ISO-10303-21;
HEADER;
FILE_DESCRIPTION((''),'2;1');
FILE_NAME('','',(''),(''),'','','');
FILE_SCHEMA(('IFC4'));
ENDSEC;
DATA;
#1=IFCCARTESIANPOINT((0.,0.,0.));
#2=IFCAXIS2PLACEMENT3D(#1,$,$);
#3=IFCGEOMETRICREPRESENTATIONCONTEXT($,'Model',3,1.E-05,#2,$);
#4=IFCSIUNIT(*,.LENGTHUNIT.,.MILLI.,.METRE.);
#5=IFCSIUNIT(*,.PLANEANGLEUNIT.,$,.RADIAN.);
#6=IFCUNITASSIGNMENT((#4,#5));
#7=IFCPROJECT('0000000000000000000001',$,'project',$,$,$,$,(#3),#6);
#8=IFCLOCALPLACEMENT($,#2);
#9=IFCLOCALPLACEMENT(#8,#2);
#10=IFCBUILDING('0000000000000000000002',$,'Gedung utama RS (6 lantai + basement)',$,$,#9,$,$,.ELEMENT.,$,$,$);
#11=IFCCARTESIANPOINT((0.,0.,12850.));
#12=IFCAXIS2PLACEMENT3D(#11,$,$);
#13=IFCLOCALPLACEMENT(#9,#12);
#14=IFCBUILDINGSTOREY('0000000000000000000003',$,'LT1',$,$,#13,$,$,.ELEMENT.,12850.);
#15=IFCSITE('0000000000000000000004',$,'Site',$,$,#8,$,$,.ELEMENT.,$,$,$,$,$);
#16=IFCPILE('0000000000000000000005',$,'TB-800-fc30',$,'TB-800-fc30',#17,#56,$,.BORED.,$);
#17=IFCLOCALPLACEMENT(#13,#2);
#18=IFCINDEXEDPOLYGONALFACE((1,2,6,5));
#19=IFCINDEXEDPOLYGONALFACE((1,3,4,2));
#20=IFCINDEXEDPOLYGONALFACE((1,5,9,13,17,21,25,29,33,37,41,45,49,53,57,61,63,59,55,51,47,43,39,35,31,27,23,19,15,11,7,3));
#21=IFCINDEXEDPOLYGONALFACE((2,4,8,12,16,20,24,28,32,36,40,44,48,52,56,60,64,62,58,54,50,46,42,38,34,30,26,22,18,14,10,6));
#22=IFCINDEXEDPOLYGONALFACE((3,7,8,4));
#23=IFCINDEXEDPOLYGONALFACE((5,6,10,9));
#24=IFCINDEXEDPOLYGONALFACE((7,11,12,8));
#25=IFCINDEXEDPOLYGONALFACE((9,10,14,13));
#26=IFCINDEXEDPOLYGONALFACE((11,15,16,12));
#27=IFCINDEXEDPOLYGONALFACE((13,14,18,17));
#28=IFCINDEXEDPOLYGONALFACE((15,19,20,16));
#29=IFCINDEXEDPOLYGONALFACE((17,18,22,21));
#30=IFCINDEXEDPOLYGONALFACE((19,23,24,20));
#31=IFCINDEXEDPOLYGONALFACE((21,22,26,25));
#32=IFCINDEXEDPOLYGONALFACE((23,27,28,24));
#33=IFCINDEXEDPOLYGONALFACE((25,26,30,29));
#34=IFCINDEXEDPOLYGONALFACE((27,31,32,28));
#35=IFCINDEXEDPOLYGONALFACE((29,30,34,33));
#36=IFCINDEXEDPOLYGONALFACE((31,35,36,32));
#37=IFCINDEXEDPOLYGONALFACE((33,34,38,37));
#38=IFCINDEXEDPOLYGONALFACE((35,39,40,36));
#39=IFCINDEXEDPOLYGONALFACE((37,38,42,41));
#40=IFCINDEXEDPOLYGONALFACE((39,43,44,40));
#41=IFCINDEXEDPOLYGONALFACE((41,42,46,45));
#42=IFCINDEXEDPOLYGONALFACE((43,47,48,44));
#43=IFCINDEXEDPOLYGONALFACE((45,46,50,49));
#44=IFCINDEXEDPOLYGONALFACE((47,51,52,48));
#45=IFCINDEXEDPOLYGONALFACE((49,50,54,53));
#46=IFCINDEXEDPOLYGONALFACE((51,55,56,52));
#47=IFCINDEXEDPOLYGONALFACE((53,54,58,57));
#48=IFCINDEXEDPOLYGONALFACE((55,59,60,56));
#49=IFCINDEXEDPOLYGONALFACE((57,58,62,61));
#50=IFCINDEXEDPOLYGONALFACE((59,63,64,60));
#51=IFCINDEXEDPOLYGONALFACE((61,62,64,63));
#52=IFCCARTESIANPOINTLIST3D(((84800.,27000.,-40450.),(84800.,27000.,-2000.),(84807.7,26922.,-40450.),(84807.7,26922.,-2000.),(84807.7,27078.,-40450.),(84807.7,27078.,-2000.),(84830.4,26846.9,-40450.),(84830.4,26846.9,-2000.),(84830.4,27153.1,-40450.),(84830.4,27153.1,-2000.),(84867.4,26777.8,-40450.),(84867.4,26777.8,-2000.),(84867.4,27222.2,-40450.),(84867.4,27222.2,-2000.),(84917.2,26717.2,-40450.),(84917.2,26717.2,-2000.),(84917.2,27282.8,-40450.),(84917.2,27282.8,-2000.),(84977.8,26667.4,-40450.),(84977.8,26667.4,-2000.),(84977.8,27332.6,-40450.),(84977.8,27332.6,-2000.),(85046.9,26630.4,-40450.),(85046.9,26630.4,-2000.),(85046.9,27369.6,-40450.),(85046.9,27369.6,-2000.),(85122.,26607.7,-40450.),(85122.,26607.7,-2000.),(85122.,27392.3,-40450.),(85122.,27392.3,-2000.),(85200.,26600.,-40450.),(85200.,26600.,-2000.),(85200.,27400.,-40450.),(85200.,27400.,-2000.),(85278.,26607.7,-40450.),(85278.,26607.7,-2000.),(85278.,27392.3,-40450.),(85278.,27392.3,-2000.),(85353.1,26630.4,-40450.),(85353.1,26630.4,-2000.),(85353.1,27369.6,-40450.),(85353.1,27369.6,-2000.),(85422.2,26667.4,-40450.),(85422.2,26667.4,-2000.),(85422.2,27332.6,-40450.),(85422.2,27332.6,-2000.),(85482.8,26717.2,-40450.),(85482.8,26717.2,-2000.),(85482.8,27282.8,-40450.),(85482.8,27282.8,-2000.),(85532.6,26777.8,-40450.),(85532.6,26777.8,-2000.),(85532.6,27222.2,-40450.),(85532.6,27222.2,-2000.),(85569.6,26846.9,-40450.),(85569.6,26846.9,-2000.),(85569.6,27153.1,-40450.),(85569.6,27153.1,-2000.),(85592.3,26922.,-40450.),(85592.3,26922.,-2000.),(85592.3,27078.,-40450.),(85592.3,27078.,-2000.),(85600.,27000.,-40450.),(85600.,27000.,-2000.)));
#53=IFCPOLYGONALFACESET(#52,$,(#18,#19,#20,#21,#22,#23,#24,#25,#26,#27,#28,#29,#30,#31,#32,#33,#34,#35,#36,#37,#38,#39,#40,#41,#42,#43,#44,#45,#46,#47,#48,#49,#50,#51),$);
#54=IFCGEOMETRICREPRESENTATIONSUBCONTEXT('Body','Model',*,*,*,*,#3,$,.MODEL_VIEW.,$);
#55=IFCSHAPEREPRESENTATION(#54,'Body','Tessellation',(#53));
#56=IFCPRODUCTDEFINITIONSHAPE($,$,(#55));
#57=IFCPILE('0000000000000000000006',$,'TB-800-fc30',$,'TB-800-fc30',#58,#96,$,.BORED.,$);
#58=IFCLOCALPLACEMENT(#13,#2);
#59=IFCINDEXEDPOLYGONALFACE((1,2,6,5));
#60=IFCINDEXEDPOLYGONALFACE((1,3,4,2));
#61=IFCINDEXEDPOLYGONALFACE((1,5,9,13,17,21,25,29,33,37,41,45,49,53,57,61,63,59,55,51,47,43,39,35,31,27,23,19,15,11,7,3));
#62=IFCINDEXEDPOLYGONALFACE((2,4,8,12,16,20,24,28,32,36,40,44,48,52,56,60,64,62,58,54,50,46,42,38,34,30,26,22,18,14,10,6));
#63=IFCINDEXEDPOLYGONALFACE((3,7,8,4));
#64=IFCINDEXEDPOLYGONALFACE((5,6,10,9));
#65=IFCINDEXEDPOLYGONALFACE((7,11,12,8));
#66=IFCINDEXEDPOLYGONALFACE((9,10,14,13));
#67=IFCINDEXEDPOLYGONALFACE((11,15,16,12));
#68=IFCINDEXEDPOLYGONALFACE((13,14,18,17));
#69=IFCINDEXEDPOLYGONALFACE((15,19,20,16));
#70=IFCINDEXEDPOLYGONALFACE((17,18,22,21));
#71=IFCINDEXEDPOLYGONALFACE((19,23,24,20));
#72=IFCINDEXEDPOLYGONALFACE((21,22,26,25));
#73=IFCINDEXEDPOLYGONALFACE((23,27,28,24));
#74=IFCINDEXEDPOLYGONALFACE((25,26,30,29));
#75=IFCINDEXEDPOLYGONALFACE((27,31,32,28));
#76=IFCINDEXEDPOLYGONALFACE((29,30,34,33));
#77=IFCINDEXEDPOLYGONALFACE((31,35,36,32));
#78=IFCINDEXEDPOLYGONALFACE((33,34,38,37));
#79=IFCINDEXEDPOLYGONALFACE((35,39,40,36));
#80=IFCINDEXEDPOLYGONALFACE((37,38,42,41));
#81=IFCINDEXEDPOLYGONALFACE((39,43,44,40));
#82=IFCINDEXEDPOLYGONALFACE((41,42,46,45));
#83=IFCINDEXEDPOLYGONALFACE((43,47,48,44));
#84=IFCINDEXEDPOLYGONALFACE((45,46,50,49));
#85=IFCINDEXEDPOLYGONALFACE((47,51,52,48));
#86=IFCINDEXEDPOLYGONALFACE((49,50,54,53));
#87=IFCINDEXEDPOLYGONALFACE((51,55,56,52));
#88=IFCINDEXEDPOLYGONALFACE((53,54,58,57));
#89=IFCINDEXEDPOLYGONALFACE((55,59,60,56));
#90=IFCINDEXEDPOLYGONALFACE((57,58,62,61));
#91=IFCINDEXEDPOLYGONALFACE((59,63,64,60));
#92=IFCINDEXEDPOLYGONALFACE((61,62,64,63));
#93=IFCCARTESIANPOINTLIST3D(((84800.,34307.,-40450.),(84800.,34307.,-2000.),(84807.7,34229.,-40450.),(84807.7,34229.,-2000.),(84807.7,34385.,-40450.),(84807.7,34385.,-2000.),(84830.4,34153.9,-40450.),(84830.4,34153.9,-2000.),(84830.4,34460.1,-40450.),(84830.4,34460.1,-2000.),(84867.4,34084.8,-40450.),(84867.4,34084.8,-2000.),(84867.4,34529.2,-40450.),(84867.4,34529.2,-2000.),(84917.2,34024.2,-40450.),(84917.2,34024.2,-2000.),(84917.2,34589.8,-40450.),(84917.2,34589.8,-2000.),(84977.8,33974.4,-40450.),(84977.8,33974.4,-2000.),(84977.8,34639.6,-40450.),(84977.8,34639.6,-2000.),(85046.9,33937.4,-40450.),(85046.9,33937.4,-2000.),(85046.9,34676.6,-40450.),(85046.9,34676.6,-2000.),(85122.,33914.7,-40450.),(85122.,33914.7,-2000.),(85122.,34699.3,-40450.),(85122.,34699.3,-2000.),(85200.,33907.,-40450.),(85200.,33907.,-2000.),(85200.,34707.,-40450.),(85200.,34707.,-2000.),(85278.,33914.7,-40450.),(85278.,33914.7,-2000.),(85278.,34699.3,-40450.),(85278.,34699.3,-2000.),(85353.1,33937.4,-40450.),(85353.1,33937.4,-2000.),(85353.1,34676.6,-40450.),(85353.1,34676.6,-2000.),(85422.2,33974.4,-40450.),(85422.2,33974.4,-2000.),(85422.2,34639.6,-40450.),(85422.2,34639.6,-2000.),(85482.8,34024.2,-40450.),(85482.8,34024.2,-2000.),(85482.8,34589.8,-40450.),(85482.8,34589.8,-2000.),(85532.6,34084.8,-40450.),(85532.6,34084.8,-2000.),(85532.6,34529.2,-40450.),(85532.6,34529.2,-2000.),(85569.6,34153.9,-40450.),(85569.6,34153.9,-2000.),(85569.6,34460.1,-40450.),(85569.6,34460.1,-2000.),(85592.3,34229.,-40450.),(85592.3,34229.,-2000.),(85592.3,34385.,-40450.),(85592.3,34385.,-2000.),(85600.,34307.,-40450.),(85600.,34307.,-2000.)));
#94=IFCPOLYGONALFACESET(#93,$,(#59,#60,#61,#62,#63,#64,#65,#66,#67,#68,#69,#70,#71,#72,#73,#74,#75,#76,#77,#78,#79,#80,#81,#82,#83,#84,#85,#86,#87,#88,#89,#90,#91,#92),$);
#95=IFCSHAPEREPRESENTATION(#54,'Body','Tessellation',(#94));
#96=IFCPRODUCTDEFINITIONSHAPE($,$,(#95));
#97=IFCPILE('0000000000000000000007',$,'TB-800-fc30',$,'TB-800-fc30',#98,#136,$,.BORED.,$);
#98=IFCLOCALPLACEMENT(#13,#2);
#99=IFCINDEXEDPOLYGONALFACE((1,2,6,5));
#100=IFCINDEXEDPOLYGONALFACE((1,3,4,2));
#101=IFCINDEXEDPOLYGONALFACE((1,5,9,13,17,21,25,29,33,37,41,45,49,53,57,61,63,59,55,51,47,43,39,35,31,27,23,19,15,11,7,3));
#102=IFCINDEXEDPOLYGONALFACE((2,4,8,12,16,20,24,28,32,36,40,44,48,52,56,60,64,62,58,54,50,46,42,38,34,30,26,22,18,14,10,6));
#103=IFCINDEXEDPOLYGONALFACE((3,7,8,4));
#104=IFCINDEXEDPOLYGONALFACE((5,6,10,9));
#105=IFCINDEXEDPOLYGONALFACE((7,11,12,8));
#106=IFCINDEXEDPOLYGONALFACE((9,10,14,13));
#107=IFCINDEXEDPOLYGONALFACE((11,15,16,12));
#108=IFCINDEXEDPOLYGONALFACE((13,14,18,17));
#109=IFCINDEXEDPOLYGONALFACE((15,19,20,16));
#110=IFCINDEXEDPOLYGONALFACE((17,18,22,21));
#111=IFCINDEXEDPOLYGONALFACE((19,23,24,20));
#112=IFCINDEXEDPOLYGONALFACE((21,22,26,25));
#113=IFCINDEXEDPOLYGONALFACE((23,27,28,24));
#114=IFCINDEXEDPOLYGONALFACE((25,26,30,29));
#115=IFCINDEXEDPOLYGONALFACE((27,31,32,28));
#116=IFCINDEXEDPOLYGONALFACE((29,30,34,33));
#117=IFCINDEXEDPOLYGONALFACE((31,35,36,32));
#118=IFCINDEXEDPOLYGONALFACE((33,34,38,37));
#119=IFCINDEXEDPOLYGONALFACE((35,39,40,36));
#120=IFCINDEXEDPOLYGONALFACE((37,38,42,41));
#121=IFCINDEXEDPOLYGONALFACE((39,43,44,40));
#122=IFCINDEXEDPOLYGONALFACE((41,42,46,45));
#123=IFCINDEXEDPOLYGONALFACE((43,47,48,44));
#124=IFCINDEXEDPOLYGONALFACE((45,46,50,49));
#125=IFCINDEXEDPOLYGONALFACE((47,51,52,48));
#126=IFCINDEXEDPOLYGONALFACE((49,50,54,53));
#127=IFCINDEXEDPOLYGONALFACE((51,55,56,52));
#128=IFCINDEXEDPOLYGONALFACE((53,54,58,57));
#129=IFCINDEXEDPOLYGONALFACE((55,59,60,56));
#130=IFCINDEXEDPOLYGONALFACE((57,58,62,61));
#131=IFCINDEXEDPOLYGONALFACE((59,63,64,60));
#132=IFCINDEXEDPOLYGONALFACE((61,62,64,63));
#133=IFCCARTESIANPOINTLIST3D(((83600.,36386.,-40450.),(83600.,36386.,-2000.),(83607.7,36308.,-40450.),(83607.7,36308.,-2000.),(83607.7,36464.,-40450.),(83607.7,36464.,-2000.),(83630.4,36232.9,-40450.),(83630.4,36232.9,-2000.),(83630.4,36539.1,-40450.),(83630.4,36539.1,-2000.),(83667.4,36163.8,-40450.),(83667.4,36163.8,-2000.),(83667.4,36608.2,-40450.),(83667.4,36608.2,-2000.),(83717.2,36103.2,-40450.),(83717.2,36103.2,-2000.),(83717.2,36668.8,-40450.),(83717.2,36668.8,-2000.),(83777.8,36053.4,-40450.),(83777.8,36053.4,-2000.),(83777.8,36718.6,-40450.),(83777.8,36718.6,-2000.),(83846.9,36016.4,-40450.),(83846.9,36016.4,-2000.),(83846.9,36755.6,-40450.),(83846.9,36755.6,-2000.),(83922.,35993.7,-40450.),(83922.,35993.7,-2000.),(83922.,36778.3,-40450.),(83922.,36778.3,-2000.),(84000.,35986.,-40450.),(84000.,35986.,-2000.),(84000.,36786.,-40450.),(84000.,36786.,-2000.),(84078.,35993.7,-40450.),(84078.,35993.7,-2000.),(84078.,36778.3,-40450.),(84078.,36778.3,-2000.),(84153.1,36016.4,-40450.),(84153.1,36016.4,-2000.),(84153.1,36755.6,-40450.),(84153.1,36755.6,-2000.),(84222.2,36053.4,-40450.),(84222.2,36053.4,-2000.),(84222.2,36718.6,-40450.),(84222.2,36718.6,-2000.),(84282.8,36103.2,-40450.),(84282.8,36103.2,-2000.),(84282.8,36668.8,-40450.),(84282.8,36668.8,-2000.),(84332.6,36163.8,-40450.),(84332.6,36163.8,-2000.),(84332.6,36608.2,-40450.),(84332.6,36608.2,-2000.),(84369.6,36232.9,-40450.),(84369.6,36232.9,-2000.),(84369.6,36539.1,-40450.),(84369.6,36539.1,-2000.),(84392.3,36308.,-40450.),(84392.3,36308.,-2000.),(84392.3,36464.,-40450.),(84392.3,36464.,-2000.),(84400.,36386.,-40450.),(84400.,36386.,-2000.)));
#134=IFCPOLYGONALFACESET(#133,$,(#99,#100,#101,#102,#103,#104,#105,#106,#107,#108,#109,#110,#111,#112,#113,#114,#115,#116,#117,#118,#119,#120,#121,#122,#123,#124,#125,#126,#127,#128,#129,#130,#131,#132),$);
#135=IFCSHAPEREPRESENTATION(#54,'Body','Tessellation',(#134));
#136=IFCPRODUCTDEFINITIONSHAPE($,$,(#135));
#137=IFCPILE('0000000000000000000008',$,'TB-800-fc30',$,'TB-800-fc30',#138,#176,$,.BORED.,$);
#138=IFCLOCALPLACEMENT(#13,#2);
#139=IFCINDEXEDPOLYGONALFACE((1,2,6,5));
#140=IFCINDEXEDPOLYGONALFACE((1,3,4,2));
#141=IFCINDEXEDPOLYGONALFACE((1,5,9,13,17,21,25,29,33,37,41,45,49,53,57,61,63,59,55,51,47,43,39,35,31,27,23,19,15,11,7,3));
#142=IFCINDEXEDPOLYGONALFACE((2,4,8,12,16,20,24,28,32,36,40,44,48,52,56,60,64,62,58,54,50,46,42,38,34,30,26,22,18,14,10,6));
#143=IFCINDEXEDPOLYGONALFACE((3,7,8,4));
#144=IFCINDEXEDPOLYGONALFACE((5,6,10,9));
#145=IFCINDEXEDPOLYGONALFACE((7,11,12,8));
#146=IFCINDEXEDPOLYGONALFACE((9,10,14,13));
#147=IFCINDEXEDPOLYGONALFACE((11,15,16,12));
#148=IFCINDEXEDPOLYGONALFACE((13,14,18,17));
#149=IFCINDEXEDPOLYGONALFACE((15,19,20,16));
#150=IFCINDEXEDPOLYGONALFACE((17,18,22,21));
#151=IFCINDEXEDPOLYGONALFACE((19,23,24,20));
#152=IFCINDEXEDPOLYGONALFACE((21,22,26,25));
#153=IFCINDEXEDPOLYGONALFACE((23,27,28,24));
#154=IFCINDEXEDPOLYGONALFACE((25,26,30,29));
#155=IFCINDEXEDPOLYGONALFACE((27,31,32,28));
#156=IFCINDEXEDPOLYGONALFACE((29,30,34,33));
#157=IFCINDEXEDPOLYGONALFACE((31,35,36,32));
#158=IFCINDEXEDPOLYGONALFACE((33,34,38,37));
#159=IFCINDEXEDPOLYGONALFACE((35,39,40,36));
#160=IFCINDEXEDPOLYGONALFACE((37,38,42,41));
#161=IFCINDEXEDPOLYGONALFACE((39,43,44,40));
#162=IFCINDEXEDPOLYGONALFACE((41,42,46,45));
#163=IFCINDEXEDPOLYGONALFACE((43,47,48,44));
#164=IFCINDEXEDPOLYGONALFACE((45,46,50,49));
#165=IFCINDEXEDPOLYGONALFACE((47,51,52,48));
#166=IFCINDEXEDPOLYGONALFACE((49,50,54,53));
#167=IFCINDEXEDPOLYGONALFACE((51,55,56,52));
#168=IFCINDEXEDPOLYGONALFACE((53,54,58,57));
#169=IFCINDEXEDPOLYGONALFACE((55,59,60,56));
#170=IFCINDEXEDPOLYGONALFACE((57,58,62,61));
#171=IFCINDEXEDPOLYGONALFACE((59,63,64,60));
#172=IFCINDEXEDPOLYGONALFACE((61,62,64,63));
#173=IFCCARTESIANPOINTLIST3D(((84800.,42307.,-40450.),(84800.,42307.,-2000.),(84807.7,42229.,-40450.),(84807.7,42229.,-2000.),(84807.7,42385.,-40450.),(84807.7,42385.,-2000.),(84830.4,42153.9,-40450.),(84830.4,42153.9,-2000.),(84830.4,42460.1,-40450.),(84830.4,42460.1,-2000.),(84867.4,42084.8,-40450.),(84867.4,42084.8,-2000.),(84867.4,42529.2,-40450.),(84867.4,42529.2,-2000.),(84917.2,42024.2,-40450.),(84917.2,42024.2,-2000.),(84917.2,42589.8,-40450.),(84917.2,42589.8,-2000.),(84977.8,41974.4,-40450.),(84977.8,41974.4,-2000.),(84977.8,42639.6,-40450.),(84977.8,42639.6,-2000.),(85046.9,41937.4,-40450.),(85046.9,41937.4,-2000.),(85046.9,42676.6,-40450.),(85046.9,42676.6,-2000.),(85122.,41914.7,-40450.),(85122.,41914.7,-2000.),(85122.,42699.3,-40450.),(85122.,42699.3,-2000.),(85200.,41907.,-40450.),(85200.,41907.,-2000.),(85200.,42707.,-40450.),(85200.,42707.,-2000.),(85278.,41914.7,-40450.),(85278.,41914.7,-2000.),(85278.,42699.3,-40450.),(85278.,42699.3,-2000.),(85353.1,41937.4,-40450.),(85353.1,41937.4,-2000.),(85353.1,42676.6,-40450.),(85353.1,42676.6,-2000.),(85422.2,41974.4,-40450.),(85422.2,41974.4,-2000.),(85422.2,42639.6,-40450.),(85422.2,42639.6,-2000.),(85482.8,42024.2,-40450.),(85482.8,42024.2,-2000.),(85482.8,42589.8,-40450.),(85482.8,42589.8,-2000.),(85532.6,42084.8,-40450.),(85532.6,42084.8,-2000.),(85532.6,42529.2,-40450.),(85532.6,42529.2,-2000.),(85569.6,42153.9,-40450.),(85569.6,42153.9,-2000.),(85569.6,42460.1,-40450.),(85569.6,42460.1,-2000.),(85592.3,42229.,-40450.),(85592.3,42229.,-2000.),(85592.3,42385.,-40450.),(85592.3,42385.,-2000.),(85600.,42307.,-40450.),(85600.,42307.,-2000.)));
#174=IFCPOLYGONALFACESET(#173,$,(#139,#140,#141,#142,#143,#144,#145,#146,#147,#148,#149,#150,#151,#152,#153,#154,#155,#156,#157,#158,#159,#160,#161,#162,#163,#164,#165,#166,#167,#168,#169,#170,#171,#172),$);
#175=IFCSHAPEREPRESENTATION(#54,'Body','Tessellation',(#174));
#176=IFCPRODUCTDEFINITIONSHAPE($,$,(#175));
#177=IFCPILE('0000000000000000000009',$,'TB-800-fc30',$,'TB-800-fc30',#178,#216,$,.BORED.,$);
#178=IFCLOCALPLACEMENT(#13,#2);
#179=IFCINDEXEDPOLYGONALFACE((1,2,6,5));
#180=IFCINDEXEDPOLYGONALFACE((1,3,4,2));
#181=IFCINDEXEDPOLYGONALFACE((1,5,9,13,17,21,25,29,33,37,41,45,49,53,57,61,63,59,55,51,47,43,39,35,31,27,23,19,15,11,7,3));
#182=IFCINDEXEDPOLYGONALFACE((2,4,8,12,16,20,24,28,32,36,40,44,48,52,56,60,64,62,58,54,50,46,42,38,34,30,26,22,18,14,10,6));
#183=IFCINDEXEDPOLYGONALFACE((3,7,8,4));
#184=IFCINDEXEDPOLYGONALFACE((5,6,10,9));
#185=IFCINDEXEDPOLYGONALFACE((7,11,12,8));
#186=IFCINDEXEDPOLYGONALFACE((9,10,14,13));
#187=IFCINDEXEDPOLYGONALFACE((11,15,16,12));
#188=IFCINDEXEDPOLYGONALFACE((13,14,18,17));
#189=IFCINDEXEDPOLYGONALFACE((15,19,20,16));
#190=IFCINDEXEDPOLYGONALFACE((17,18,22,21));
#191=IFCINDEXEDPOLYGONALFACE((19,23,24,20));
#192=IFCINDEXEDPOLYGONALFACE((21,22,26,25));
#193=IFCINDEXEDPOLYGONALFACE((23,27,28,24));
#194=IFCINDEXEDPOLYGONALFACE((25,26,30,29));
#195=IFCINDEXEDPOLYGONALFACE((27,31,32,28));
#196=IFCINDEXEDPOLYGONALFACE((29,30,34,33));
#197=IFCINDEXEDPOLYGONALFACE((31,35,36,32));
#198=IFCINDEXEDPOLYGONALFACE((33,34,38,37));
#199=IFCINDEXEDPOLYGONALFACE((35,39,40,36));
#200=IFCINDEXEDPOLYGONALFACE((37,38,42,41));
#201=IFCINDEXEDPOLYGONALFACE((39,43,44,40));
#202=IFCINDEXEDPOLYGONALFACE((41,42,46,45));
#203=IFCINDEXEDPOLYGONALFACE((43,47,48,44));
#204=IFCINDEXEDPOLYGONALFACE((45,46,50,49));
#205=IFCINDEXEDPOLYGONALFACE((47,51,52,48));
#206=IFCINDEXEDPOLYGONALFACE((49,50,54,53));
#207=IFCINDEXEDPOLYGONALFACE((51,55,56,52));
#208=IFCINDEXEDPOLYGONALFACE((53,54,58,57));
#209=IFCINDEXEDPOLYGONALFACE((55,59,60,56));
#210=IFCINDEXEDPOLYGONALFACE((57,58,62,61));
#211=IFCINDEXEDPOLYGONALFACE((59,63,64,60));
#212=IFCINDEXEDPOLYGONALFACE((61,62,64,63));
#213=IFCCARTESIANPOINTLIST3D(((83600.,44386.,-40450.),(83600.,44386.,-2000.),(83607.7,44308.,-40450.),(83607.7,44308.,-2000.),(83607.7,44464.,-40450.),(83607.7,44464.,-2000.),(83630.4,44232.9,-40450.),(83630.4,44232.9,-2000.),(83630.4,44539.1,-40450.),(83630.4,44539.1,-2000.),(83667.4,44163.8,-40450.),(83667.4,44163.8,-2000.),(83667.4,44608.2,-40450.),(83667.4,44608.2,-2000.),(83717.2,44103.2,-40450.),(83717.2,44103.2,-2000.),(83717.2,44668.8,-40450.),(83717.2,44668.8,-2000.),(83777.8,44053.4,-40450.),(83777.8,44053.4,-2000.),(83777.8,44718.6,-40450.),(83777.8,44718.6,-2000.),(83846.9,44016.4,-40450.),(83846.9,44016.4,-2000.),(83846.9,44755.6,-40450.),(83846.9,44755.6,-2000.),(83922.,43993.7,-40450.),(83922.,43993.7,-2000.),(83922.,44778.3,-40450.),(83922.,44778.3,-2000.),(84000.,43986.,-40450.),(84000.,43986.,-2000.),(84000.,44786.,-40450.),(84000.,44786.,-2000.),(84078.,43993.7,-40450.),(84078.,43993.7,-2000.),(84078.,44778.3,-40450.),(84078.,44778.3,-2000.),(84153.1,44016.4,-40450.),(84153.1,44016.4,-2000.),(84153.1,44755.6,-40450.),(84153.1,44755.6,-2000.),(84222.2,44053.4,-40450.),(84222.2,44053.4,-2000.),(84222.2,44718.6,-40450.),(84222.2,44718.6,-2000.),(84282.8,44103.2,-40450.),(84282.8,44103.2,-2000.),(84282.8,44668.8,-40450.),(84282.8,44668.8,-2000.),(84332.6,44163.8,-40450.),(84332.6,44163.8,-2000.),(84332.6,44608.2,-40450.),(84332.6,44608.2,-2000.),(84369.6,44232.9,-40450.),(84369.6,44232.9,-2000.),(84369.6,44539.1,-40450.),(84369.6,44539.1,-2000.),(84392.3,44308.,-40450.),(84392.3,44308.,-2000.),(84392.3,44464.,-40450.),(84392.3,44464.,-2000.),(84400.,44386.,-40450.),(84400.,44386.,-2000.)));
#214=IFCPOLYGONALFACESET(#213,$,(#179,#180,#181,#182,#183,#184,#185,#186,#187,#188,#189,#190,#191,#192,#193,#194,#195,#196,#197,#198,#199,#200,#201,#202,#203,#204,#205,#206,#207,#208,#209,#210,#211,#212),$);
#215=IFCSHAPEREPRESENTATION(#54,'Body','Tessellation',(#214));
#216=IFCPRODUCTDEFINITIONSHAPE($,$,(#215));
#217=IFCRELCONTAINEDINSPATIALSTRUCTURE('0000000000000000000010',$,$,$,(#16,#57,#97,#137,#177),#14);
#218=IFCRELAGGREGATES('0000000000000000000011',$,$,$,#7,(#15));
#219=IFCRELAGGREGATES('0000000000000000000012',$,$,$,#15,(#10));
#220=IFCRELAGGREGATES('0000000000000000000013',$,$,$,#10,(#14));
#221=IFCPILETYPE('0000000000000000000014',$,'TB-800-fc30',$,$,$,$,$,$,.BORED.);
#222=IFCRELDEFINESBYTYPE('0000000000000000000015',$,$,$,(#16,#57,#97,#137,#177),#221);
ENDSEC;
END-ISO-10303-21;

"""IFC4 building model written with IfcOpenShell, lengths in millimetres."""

from ifc_helpers import new_model, si_unit, frame, origin, origin_2d, place, context, subcontext, project, spatial, circle, extrude, material_profile, profile_set, profile_usage, type_object, element, save


model = new_model("IFC4")

# Units and contexts
model_context = context("Model", 3, precision=1e-05, world=origin())
body_context = subcontext(model_context, "Body", "Model", "MODEL_VIEW")
ifc_project = project(units=[si_unit("LENGTHUNIT", "METRE", prefix="MILLI"), si_unit("PLANEANGLEUNIT", "RADIAN")], contexts=[model_context])

# Site, building, storey
site_placement = place(None, origin())
site = spatial("IfcSite", under=ifc_project, at=site_placement, Name="Site", CompositionType="ELEMENT")
building_placement = place(site_placement, origin())
building = spatial("IfcBuilding", under=site, at=building_placement, Name="Gedung utama RS (6 lantai + basement)", CompositionType="ELEMENT")
storey_placement = place(building_placement, frame((0.0, 0.0, 12850.0)))
storey = spatial("IfcBuildingStorey", under=building, at=storey_placement, Name="LT1", CompositionType="ELEMENT", Elevation=12850.0)

# Piles
ifc_material_profile_1 = material_profile(None, circle(Radius=400.0, at=origin_2d()), Name="TB-800-fc30")
ifc_profile_set_1 = profile_set([ifc_material_profile_1], Name="TB-800-fc30")
ifc_profile_usage_1 = profile_usage(ifc_profile_set_1, cardinal=5)
pile_type = type_object("IfcPileType", Name="TB-800-fc30", PredefinedType="BORED", material=ifc_profile_set_1)
for number, where, z_axis, x_axis, name in (
    (1, (85200.0, 27000.0, -40450.0), (0.0, 0.0, 1.0), (1.0, 0.0, 0.0), "TB-800-fc30"),
    (2, (85200.0, 34307.0, -40450.0), (0.0, 0.0, 1.0), (1.0, 0.0, 0.0), "TB-800-fc30"),
    (3, (84000.0, 36386.0, -40450.0), (0.0, 0.0, 1.0), (1.0, 0.0, 0.0), "TB-800-fc30"),
    (4, (85200.0, 42307.0, -40450.0), (0.0, 0.0, 1.0), (1.0, 0.0, 0.0), "TB-800-fc30"),
    (5, (84000.0, 44386.0, -40450.0), (0.0, 0.0, 1.0), (1.0, 0.0, 0.0), "TB-800-fc30"),
):
    element("IfcPile", number, at=place(storey_placement, frame(where, z_axis=z_axis, x_axis=x_axis)), inside=storey, type_object=pile_type, material=ifc_profile_usage_1, Name=name, ObjectType="TB-800-fc30", PredefinedType="BORED", context=body_context, shape_type="SweptSolid", body=[
        extrude(circle(Radius=400.0, at=origin_2d()), origin(), (0.0, 0.0, 1.0), 38450.0),
    ])

save(model, "model.ifc")
